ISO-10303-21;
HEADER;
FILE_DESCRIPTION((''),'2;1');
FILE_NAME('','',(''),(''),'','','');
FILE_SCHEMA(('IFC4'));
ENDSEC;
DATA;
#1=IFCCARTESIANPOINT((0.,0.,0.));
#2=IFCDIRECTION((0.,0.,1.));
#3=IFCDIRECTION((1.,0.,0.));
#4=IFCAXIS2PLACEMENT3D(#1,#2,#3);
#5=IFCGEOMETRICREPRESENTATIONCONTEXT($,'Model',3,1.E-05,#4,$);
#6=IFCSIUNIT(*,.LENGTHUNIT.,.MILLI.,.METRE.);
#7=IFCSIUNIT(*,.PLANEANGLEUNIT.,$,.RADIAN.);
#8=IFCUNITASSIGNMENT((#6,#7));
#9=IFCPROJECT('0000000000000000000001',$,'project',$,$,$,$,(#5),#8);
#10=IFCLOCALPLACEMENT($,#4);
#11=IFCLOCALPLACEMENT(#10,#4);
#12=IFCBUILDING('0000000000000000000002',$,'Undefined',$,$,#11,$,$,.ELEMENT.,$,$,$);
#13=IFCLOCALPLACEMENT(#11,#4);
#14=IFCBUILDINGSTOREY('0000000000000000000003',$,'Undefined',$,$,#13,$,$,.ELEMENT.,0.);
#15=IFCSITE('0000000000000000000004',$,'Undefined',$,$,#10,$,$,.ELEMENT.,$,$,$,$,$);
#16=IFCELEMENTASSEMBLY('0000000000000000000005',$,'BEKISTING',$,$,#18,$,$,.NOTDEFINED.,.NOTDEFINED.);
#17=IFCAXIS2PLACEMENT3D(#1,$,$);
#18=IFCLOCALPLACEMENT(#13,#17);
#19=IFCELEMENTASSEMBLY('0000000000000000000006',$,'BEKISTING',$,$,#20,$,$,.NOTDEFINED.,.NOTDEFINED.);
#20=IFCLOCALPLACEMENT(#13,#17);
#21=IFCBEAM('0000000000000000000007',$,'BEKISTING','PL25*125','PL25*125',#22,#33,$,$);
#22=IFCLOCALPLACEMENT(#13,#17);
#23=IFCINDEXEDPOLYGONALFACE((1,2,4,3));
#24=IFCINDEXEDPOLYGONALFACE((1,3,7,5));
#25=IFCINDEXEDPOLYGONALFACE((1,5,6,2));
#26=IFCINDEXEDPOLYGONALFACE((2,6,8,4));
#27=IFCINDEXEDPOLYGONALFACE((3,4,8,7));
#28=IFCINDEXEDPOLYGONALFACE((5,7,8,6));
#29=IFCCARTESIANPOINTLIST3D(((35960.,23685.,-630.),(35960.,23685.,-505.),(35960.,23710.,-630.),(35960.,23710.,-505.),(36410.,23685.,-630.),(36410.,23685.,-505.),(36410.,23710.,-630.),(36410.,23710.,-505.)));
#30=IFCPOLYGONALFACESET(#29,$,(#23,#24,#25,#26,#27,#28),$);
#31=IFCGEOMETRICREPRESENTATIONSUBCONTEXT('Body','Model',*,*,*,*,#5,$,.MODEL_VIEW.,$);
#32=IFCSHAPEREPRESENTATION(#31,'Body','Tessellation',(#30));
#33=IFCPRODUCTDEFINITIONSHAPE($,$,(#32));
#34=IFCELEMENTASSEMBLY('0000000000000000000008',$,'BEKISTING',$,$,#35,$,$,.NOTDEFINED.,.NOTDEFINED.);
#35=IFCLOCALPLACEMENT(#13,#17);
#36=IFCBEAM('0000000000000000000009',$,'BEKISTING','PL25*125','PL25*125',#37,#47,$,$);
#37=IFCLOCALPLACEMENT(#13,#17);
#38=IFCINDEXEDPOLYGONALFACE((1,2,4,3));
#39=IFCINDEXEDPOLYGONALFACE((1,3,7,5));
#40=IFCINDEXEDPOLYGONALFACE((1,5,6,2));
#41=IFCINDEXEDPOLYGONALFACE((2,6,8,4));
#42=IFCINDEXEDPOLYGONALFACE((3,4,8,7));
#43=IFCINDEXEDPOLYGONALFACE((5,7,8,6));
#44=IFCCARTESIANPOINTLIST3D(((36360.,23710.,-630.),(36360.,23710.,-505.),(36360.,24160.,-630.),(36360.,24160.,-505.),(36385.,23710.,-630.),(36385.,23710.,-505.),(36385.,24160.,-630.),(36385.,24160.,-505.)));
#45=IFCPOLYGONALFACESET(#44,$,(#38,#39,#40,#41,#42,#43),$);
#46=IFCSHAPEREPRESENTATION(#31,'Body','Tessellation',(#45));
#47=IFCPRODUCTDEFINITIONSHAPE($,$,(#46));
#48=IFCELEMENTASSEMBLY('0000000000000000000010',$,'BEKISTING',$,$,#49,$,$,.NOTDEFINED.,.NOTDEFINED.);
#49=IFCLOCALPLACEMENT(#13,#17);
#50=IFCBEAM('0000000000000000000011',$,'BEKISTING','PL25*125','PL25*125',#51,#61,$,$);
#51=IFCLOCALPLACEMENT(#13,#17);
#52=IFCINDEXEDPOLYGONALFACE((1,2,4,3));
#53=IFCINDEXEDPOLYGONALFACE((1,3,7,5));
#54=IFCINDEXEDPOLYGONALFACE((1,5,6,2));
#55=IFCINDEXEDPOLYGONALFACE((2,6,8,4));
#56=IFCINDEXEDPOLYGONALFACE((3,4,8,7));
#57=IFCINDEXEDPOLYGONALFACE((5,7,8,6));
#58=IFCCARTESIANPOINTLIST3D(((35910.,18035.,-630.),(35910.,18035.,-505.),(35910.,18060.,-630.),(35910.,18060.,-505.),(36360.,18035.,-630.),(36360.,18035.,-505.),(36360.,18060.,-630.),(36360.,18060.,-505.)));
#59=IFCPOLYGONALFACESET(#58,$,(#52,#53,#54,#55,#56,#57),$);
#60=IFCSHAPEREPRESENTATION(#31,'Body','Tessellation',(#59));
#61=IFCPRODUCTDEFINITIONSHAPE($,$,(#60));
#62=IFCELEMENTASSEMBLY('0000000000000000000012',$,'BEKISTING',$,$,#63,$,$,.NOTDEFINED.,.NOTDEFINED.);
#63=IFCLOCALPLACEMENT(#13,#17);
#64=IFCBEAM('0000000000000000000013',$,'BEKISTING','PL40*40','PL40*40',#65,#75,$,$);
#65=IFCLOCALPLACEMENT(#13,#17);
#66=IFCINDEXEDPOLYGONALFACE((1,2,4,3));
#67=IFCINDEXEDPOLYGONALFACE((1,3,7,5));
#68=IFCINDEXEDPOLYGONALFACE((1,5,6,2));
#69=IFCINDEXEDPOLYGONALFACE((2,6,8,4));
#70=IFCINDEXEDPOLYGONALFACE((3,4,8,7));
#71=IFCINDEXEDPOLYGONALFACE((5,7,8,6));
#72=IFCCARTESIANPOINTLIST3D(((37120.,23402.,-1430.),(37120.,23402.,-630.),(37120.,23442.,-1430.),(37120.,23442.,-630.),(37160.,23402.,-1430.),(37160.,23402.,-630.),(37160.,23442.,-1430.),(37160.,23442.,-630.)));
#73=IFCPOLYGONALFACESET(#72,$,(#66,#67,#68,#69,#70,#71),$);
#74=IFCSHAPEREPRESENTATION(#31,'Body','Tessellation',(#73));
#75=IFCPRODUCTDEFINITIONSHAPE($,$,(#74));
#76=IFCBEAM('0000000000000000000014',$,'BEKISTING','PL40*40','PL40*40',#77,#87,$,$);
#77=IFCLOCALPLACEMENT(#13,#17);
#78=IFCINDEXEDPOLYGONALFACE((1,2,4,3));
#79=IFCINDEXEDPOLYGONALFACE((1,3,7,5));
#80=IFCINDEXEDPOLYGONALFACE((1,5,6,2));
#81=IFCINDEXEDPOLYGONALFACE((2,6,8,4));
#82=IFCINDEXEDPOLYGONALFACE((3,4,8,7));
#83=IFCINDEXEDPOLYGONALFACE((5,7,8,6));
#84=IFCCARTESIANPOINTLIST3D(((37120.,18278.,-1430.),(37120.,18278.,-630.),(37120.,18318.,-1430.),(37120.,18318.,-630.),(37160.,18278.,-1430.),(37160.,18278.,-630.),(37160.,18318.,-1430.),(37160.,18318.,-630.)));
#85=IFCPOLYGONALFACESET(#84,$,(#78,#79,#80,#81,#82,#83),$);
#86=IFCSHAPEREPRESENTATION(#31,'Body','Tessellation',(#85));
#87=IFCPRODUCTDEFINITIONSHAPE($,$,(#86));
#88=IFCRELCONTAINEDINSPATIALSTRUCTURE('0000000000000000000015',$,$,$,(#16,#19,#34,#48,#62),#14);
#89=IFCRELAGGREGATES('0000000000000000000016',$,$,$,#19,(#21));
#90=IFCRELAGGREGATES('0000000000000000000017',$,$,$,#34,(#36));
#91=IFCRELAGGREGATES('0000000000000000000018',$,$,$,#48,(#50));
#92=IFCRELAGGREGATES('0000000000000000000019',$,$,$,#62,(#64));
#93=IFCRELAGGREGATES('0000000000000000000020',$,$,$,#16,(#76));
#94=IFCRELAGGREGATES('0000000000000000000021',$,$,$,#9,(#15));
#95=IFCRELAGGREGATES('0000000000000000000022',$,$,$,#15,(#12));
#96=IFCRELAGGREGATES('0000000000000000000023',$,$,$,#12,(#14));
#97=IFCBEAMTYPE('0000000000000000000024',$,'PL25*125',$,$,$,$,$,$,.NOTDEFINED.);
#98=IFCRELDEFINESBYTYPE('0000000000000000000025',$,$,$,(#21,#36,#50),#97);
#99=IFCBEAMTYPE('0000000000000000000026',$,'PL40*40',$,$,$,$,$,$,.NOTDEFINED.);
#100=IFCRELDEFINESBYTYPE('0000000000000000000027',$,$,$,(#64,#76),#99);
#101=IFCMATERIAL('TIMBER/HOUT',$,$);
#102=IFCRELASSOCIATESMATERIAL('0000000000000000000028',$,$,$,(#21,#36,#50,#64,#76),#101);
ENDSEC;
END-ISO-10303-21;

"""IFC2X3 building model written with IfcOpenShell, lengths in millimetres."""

from ifc_helpers import new_model, si_unit, frame, frame_2d, origin_with_axes, place, context, subcontext, project, spatial, rectangle, extrude, material, type_object, element, aggregate, save


model = new_model("IFC2X3")

# Units and contexts
model_context = context("Model", 3, precision=1e-05, world=origin_with_axes())
body_context = subcontext(model_context, "Body", "Model", "MODEL_VIEW")
ifc_project = project(units=[si_unit("LENGTHUNIT", "METRE", prefix="MILLI"), si_unit("PLANEANGLEUNIT", "RADIAN")], contexts=[model_context])

# Site, building, storey
site_placement = place(None, origin_with_axes())
site = spatial("IfcSite", under=ifc_project, at=site_placement, Name="Undefined", CompositionType="ELEMENT")
building_placement = place(site_placement, origin_with_axes())
building = spatial("IfcBuilding", under=site, at=building_placement, Name="Undefined", CompositionType="ELEMENT")
storey_placement = place(building_placement, origin_with_axes())
storey = spatial("IfcBuildingStorey", under=building, at=storey_placement, Name="Undefined", CompositionType="ELEMENT", Elevation=0.0)

# Element assembly
ifc_material_1 = material(Name="TIMBER/HOUT")
assembly_1_placement = place(storey_placement, origin_with_axes())
assembly_1 = element("IfcElementAssembly", 1, at=assembly_1_placement, inside=storey, Name="BEKISTING", AssemblyPlace="NOTDEFINED", PredefinedType="NOTDEFINED")

# Element assemblies, beams
assembly_2_placement = place(storey_placement, origin_with_axes())
assembly_2 = element("IfcElementAssembly", 2, at=assembly_2_placement, inside=storey, Name="BEKISTING", AssemblyPlace="NOTDEFINED", PredefinedType="NOTDEFINED")
beam_type_1 = type_object("IfcBeamType", Name="PL25*125", PredefinedType="NOTDEFINED")
beam_1_placement = place(assembly_2_placement, frame((36410.0, 23697.5, -567.5), z_axis=(0.0, 0.0, -1.0), x_axis=(-1.0, 0.0, 0.0)))
beam_1 = element("IfcBeam", 3, at=beam_1_placement, type_object=beam_type_1, material=ifc_material_1, Name="BEKISTING", Description="PL25*125", ObjectType="PL25*125", context=body_context, shape_type="SweptSolid", body=[
    extrude(rectangle(XDim=25.0, YDim=125.0, at=frame_2d((0.0, 0.0), x_axis=(1.0, 0.0))), frame((450.0, 0.0, 0.0), z_axis=(-1.0, 0.0, 0.0), x_axis=(0.0, -1.0, 0.0)), (0.0, 0.0, 1.0), 450.0),
])
aggregate(assembly_2, [beam_1])
assembly_3_placement = place(storey_placement, origin_with_axes())
assembly_3 = element("IfcElementAssembly", 4, at=assembly_3_placement, inside=storey, Name="BEKISTING", AssemblyPlace="NOTDEFINED", PredefinedType="NOTDEFINED")
beam_2_placement = place(assembly_3_placement, frame((36372.5, 23710.0, -567.5), z_axis=(0.0, 0.0, -1.0), x_axis=(0.0, 1.0, 0.0)))
beam_2 = element("IfcBeam", 5, at=beam_2_placement, type_object=beam_type_1, material=ifc_material_1, Name="BEKISTING", Description="PL25*125", ObjectType="PL25*125", context=body_context, shape_type="SweptSolid", body=[
    extrude(rectangle(XDim=25.0, YDim=125.0, at=frame_2d((0.0, 0.0), x_axis=(1.0, 0.0))), frame((450.0, 0.0, 0.0), z_axis=(-1.0, 0.0, 0.0), x_axis=(0.0, -1.0, 0.0)), (0.0, 0.0, 1.0), 450.0),
])
aggregate(assembly_3, [beam_2])
assembly_4_placement = place(storey_placement, origin_with_axes())
assembly_4 = element("IfcElementAssembly", 6, at=assembly_4_placement, inside=storey, Name="BEKISTING", AssemblyPlace="NOTDEFINED", PredefinedType="NOTDEFINED")
beam_3_placement = place(assembly_4_placement, frame((36360.0, 18047.5, -567.5), z_axis=(0.0, 0.0, -1.0), x_axis=(-1.0, 0.0, 0.0)))
beam_3 = element("IfcBeam", 7, at=beam_3_placement, type_object=beam_type_1, material=ifc_material_1, Name="BEKISTING", Description="PL25*125", ObjectType="PL25*125", context=body_context, shape_type="SweptSolid", body=[
    extrude(rectangle(XDim=25.0, YDim=125.0, at=frame_2d((0.0, 0.0), x_axis=(1.0, 0.0))), frame((450.0, 0.0, 0.0), z_axis=(-1.0, 0.0, 0.0), x_axis=(0.0, -1.0, 0.0)), (0.0, 0.0, 1.0), 450.0),
])
aggregate(assembly_4, [beam_3])
assembly_5_placement = place(storey_placement, origin_with_axes())
assembly_5 = element("IfcElementAssembly", 8, at=assembly_5_placement, inside=storey, Name="BEKISTING", AssemblyPlace="NOTDEFINED", PredefinedType="NOTDEFINED")
beam_type_2 = type_object("IfcBeamType", Name="PL40*40", PredefinedType="NOTDEFINED")
beam_4_placement = place(assembly_5_placement, frame((37140.0, 23422.0, -1430.0), z_axis=(0.0, 1.0, 0.0), x_axis=(0.0, 0.0, 1.0)))
beam_4 = element("IfcBeam", 9, at=beam_4_placement, type_object=beam_type_2, material=ifc_material_1, Name="BEKISTING", Description="PL40*40", ObjectType="PL40*40", context=body_context, shape_type="SweptSolid", body=[
    extrude(rectangle(XDim=40.0, YDim=40.0, at=frame_2d((0.0, 0.0), x_axis=(1.0, 0.0))), frame((800.0, 0.0, 0.0), z_axis=(-1.0, 0.0, 0.0), x_axis=(0.0, -1.0, 0.0)), (0.0, 0.0, 1.0), 800.0),
])
aggregate(assembly_5, [beam_4])

# Beam
beam_5_placement = place(assembly_1_placement, frame((37140.0, 18298.0, -1430.0), z_axis=(0.0, 1.0, 0.0), x_axis=(0.0, 0.0, 1.0)))
beam_5 = element("IfcBeam", 10, at=beam_5_placement, type_object=beam_type_2, material=ifc_material_1, Name="BEKISTING", Description="PL40*40", ObjectType="PL40*40", context=body_context, shape_type="SweptSolid", body=[
    extrude(rectangle(XDim=40.0, YDim=40.0, at=frame_2d((0.0, 0.0), x_axis=(1.0, 0.0))), frame((800.0, 0.0, 0.0), z_axis=(-1.0, 0.0, 0.0), x_axis=(0.0, -1.0, 0.0)), (0.0, 0.0, 1.0), 800.0),
])
aggregate(assembly_1, [beam_5])

save(model, "model.ifc")
